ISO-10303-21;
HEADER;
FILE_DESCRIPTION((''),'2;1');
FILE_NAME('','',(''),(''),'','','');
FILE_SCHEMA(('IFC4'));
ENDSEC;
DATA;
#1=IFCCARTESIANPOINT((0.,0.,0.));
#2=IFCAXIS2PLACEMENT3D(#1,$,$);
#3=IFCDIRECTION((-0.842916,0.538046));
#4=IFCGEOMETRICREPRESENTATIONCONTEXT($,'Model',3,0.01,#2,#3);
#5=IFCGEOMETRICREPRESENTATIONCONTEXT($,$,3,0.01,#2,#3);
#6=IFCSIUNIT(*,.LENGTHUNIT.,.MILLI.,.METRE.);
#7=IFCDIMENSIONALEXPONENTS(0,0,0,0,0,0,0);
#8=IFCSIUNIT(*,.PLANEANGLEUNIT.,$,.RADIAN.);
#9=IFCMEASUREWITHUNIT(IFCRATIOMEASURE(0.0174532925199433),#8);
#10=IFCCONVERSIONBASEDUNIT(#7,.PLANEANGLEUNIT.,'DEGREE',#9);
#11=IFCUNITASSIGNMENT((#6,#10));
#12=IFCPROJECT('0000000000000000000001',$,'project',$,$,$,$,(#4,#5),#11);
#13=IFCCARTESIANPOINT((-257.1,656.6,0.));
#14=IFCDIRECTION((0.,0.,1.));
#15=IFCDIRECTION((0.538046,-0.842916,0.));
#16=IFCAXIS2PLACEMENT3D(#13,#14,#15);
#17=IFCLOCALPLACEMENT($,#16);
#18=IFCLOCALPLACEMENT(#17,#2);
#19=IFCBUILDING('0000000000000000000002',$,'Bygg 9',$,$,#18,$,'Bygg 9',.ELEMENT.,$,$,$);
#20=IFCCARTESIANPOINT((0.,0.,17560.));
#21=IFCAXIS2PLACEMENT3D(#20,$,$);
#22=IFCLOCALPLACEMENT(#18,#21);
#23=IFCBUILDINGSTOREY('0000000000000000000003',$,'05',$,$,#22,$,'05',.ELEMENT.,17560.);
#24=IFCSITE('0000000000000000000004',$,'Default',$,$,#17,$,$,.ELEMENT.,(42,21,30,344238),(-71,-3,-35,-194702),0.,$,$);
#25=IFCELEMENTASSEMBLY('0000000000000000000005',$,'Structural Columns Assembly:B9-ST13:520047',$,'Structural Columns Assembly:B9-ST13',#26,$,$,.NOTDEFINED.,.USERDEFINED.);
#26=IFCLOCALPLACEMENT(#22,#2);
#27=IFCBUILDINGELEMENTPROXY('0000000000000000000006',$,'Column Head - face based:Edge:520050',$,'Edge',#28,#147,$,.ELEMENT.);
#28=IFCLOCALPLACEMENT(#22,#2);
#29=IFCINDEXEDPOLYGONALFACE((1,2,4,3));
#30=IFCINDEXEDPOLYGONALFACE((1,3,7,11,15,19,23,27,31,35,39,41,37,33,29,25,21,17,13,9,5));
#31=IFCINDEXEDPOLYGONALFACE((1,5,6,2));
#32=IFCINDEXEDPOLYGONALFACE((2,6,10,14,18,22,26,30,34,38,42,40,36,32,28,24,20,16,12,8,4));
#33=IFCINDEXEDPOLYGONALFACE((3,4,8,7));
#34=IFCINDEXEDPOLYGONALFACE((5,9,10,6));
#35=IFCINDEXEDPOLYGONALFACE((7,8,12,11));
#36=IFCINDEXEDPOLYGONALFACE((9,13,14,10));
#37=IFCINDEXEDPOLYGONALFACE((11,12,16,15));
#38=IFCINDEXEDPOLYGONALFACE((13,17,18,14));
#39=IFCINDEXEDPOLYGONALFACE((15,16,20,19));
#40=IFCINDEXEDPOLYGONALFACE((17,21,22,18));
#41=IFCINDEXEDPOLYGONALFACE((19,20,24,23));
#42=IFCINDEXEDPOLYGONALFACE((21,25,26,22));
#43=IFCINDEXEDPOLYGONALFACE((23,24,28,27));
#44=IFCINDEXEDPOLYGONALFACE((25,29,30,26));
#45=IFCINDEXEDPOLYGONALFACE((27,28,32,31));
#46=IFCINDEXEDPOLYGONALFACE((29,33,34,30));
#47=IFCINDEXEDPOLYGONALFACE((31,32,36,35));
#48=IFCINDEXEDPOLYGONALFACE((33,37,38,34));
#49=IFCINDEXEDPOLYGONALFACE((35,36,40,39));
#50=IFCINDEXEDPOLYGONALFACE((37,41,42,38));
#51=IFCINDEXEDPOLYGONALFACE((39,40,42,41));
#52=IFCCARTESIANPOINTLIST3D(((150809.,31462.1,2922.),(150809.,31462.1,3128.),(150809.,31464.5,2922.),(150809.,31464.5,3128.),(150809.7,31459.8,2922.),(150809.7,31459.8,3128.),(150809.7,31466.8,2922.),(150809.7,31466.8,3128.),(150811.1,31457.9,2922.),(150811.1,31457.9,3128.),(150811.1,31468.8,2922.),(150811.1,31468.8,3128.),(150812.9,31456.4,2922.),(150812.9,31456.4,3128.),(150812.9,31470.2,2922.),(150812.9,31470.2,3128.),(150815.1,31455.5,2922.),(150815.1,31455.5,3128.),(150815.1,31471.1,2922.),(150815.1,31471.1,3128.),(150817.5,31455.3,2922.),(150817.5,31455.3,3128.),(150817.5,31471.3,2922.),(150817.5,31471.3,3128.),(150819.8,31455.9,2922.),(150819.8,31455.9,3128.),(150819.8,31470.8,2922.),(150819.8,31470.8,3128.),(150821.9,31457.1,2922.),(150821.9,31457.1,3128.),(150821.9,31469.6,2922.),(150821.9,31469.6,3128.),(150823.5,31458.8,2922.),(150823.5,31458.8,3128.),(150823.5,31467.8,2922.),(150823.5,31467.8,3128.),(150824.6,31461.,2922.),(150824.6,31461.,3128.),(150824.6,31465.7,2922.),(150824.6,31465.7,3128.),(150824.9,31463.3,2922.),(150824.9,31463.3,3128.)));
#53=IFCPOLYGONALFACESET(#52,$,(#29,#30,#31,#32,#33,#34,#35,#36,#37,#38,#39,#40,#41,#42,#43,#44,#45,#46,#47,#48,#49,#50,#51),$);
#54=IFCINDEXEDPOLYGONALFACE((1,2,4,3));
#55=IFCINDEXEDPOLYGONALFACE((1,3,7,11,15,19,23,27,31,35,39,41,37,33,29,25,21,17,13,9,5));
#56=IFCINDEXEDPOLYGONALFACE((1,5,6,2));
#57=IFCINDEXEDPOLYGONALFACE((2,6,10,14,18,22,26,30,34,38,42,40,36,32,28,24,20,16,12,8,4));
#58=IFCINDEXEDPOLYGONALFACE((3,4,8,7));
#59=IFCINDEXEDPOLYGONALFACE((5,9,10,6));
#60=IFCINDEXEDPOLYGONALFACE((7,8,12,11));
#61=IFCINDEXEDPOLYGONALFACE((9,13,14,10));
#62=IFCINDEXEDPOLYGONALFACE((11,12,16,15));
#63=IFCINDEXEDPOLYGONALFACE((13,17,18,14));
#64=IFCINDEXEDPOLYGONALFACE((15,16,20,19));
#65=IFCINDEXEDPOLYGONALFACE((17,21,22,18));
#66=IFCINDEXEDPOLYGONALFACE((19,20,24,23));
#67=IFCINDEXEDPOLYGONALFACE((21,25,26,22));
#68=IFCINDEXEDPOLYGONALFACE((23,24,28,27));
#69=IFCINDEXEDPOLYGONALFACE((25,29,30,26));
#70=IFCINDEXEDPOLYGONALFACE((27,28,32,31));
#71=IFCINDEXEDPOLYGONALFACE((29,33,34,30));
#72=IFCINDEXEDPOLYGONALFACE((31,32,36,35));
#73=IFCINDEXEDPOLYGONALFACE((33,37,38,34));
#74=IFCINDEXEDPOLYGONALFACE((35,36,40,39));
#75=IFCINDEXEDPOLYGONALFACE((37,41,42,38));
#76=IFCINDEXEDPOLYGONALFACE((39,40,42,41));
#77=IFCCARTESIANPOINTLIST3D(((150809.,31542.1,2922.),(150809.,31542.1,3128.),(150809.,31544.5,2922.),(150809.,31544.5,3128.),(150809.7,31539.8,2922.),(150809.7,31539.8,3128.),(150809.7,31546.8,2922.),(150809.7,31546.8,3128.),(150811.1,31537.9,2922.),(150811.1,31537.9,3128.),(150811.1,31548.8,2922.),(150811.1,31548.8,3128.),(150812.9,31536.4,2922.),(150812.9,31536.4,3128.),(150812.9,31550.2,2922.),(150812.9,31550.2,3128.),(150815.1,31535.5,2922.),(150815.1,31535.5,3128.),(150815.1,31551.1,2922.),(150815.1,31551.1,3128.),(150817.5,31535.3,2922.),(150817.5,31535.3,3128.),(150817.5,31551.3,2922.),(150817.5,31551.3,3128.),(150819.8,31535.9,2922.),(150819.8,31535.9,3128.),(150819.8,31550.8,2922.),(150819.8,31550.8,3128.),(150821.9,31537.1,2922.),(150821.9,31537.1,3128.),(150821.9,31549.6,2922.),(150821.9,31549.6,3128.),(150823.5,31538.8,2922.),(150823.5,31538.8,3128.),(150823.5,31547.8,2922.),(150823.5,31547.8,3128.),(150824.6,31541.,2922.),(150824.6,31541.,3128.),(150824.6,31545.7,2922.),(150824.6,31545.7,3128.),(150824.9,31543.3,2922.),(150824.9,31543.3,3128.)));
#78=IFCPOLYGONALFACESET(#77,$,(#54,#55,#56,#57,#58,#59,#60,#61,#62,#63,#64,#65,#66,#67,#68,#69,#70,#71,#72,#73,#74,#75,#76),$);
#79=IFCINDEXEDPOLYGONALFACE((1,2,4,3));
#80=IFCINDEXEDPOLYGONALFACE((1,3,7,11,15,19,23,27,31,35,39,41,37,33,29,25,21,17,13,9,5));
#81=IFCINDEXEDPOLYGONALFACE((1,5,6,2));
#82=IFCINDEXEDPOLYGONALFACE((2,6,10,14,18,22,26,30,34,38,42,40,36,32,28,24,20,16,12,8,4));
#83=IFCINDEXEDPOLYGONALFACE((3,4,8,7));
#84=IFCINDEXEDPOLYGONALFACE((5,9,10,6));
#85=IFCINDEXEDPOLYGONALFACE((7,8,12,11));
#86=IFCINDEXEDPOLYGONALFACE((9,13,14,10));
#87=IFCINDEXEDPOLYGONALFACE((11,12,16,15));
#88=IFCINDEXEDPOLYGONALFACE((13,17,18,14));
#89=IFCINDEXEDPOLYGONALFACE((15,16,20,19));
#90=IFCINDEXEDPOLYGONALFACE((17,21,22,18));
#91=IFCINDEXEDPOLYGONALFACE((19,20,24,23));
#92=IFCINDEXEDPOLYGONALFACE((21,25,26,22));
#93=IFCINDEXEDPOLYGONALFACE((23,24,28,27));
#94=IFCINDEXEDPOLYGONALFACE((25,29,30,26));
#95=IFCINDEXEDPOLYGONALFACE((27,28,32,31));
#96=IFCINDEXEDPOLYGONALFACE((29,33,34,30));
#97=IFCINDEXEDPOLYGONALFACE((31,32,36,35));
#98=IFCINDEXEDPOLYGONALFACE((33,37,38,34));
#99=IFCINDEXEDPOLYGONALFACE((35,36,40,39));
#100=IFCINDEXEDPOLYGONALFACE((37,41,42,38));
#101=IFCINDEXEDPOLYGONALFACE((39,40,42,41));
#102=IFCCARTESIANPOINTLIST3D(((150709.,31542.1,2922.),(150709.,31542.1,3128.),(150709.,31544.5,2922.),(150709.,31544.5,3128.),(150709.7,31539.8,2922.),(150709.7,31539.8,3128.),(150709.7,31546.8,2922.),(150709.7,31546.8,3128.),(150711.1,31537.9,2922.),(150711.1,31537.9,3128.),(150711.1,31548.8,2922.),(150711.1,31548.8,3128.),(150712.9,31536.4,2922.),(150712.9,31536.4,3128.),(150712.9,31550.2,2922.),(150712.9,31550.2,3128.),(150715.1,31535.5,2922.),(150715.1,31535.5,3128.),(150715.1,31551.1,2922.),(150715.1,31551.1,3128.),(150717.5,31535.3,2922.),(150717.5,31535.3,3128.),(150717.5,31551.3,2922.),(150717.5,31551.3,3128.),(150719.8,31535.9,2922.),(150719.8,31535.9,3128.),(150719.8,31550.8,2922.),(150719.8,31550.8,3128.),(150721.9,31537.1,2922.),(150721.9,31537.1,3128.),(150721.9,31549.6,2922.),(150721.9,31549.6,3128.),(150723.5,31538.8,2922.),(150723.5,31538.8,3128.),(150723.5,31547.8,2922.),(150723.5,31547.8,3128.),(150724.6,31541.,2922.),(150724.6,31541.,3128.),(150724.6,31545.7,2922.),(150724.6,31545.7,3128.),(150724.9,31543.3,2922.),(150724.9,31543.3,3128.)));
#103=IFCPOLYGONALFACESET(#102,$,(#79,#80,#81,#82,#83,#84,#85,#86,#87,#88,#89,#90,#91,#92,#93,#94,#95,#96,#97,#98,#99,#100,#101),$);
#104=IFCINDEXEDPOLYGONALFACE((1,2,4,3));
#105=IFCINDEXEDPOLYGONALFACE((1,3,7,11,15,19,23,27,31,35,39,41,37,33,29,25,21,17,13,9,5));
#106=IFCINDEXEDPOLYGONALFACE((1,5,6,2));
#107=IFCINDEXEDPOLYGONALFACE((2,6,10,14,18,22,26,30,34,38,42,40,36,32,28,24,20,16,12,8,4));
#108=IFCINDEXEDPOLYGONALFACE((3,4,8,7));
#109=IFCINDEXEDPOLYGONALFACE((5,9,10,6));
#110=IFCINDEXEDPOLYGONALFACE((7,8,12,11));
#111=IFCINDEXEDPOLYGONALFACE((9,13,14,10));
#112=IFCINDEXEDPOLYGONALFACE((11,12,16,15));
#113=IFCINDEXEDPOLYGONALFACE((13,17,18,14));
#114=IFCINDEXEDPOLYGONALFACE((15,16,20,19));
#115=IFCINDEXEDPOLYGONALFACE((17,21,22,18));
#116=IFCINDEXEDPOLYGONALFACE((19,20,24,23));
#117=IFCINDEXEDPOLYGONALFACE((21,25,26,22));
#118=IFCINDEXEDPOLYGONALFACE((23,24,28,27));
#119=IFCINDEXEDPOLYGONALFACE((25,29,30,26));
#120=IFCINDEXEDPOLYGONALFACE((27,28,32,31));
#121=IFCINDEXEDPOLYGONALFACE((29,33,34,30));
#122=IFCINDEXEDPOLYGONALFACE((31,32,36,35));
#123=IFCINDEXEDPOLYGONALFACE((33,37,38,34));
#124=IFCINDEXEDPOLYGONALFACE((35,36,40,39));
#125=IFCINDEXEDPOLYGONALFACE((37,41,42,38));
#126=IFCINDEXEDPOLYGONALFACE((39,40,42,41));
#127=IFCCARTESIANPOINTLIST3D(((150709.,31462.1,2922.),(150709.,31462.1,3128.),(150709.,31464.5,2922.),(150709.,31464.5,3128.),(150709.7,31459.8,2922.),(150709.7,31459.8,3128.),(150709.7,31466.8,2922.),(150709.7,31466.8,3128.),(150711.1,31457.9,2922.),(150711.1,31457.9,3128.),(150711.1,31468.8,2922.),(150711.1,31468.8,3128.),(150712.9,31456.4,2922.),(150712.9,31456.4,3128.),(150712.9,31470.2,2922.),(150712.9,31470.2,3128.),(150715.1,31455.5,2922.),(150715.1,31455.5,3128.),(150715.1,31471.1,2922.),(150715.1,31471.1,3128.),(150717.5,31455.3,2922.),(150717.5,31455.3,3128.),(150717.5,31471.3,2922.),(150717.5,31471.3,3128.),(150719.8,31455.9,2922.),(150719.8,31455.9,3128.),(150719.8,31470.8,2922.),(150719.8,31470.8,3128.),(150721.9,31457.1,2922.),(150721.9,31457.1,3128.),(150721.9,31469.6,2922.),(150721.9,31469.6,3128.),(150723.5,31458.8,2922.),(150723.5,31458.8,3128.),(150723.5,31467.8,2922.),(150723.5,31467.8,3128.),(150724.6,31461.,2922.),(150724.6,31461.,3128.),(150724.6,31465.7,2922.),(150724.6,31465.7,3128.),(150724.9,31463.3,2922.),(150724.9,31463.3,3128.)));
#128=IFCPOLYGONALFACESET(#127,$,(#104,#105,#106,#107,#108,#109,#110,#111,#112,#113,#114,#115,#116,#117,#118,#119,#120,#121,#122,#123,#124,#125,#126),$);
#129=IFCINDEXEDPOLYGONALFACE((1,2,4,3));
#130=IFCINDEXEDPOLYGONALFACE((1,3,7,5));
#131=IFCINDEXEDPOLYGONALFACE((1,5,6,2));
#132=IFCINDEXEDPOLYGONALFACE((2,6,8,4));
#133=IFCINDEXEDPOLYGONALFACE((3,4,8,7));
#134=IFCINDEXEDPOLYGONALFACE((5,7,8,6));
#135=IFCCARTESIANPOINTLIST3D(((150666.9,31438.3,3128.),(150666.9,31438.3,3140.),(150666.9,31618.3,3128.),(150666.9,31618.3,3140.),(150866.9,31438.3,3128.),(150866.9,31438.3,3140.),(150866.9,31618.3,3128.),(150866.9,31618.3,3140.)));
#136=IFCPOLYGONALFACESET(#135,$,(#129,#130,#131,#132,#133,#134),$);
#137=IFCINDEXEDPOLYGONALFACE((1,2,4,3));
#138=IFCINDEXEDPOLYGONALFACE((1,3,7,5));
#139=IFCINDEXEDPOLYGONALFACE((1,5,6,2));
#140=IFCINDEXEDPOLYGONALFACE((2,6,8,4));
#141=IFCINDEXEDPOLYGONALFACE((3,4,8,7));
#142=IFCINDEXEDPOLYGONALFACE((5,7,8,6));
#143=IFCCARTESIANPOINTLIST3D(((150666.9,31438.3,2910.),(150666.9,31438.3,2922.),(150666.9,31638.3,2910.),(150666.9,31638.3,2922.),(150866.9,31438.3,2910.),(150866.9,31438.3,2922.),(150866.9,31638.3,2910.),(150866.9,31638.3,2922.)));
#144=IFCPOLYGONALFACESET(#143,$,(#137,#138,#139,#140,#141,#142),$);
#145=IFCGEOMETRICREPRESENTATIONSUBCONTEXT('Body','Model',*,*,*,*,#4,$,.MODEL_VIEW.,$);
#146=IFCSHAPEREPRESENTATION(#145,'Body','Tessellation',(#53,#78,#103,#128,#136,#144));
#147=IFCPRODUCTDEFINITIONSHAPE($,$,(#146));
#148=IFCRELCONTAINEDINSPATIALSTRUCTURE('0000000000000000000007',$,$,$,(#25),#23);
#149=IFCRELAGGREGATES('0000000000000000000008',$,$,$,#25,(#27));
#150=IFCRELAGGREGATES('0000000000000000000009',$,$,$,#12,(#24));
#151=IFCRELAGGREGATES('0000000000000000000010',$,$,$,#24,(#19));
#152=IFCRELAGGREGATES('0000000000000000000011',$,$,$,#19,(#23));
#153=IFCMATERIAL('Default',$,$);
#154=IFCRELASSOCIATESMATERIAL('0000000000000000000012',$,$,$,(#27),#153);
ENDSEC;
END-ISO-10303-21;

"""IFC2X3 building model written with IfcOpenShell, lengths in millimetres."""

from ifc_helpers import new_model, entity, si_unit, converted_unit, direction, frame, frame_2d, origin, origin_2d_with_axis, place, context, subcontext, project, spatial, rectangle, circle, extrude, source, transform, mapped, material, element, aggregate, save


model = new_model("IFC2X3")

# Units and contexts
model_context = context("Model", 3, precision=0.01, world=origin(), true_north=direction((-0.842916, 0.538046)))
context_of_model = context(None, 3, precision=0.01, world=origin(), true_north=direction((-0.842916, 0.538046)))
body_context = subcontext(model_context, "Body", "Model", "MODEL_VIEW")
ifc_project = project(units=[si_unit("LENGTHUNIT", "METRE", prefix="MILLI"), converted_unit("PLANEANGLEUNIT", "DEGREE", entity("IfcRatioMeasure", 0.0174532925199433), si_unit("PLANEANGLEUNIT", "RADIAN"), dimensions=[0, 0, 0, 0, 0, 0, 0])], contexts=[model_context, context_of_model])

# Site, building, storey
site_placement = place(None, frame((-257.1, 656.6, 0.0), z_axis=(0.0, 0.0, 1.0), x_axis=(0.538046, -0.842916, 0.0)))
site = spatial("IfcSite", under=ifc_project, at=site_placement, Name="Default", CompositionType="ELEMENT", RefLatitude=(42, 21, 30, 344238), RefLongitude=(-71, -3, -35, -194702), RefElevation=0.0)
building_placement = place(site_placement, origin())
building = spatial("IfcBuilding", under=site, at=building_placement, Name="Bygg 9", LongName="Bygg 9", CompositionType="ELEMENT")
storey_placement = place(building_placement, frame((0.0, 0.0, 17560.0)))
storey = spatial("IfcBuildingStorey", under=building, at=storey_placement, Name="05", LongName="05", CompositionType="ELEMENT", Elevation=17560.0)

# Shared definitions
ifc_material_1 = material(Name="Default")

# Element assembly, building element proxy
shared_shape_1 = source(origin(), body_context, "Body", "SweptSolid", [
    extrude(circle(Radius=8.0, at=frame_2d((0.0, 0.0), x_axis=(1.0, 0.0))), frame((50.0, -135.0, 12.0)), (0.0, 0.0, 1.0), 206.0),
    extrude(circle(Radius=8.0, at=frame_2d((0.0, 0.0), x_axis=(1.0, 0.0))), frame((50.0, -55.0, 12.0)), (0.0, 0.0, 1.0), 206.0),
    extrude(circle(Radius=8.0, at=frame_2d((0.0, 0.0), x_axis=(1.0, 0.0))), frame((-50.0, -55.0, 12.0)), (0.0, 0.0, 1.0), 206.0),
    extrude(circle(Radius=8.0, at=frame_2d((0.0, 0.0), x_axis=(1.0, 0.0))), frame((-50.0, -135.0, 12.0)), (0.0, 0.0, 1.0), 206.0),
    extrude(rectangle(XDim=200.0, YDim=180.0, at=origin_2d_with_axis()), frame((0.0, -70.0, 218.0), z_axis=(0.0, 0.0, 1.0), x_axis=(-1.0, 0.0, 0.0)), (0.0, 0.0, 1.0), 12.0),
    extrude(rectangle(XDim=200.0, YDim=200.0, at=origin_2d_with_axis()), frame((0.0, -60.0, 0.0), z_axis=(0.0, 0.0, 1.0), x_axis=(0.0, 1.0, 0.0)), (0.0, 0.0, 1.0), 12.0),
])
assembly_1_placement = place(storey_placement, origin())
assembly_1 = element("IfcElementAssembly", 1, at=assembly_1_placement, inside=storey, Name="Structural Columns Assembly:B9-ST13:520047", ObjectType="Structural Columns Assembly:B9-ST13", AssemblyPlace="NOTDEFINED", PredefinedType="USERDEFINED")
proxy_1_placement = place(assembly_1_placement, frame((150766.9, 31598.3, 2910.0)))
proxy_1 = element("IfcBuildingElementProxy", 2, at=proxy_1_placement, material=ifc_material_1, Name="Column Head - face based:Edge:520050", ObjectType="Edge", CompositionType="ELEMENT", context=body_context, shape_type="MappedRepresentation", body=[
    mapped(shared_shape_1, transform((0.0, 0.0, 0.0), scale=1.0)),
])
aggregate(assembly_1, [proxy_1])

save(model, "model.ifc")
